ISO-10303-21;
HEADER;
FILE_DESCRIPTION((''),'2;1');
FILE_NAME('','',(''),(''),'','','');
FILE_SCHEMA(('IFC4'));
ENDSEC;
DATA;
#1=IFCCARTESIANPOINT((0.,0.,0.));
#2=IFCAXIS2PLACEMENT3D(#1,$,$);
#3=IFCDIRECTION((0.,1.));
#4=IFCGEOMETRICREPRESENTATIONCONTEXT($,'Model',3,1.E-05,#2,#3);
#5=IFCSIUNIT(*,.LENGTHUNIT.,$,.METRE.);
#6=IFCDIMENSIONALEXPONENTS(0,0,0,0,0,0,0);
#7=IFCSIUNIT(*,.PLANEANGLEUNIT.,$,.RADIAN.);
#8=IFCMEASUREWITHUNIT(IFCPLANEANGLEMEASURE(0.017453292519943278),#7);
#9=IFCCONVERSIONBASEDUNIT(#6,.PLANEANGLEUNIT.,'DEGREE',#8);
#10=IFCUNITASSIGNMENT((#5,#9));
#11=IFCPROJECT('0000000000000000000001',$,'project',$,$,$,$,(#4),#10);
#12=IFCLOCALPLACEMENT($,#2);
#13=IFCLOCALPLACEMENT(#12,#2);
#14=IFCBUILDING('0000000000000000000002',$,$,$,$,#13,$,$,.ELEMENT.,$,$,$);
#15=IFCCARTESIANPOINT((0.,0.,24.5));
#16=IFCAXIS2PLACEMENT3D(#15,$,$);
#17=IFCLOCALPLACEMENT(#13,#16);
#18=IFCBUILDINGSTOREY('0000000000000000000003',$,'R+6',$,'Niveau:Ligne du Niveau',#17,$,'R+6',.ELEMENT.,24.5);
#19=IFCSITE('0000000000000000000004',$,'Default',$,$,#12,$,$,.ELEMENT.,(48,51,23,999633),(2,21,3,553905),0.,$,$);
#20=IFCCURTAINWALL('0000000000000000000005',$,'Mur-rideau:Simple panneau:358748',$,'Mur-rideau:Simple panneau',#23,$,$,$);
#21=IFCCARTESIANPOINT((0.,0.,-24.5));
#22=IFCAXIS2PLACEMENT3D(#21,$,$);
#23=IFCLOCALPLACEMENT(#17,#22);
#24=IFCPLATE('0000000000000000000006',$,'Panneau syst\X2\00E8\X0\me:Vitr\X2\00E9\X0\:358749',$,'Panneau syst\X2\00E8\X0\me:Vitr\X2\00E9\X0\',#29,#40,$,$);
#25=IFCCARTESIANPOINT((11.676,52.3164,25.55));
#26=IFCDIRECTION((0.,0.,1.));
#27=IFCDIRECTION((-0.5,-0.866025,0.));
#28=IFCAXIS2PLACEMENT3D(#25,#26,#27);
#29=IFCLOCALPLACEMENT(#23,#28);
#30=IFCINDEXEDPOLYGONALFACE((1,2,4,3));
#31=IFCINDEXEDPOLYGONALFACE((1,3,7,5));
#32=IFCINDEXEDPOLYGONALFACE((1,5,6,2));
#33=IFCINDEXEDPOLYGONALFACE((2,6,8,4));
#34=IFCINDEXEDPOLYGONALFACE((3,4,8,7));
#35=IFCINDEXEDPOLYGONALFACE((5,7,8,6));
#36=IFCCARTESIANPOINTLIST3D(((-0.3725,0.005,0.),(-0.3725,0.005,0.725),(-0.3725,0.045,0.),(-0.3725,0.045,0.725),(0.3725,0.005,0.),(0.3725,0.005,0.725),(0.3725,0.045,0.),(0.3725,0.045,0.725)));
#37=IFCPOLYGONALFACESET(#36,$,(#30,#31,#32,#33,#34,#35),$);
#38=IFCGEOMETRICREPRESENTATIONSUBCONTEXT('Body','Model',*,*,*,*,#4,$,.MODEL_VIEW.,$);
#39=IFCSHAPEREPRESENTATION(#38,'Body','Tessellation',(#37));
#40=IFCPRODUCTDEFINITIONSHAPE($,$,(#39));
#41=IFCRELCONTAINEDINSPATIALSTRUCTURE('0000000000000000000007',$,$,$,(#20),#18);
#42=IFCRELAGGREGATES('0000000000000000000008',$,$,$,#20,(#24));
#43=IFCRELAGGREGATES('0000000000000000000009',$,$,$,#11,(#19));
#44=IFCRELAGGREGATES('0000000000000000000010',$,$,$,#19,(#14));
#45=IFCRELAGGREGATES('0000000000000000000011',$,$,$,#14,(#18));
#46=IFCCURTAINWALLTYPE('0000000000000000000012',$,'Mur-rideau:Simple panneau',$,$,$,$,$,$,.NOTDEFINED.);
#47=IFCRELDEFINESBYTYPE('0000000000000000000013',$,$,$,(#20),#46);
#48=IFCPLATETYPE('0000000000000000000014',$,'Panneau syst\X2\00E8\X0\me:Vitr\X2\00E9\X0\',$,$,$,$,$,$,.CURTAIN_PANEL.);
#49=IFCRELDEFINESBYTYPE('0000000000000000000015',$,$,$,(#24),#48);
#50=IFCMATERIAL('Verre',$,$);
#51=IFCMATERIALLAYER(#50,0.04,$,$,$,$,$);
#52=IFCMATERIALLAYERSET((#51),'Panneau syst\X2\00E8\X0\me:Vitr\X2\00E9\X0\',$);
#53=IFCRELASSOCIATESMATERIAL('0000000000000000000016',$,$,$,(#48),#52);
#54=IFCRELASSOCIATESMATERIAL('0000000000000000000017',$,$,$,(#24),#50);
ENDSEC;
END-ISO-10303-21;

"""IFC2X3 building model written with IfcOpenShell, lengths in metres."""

from ifc_helpers import new_model, entity, si_unit, converted_unit, direction, frame, frame_2d, origin, place, context, subcontext, project, spatial, rectangle, extrude, source, transform, mapped, material, layer, layer_set, type_object, type_shapes, element, aggregate, save


model = new_model("IFC2X3")

# Units and contexts
model_context = context("Model", 3, precision=1e-05, world=origin(), true_north=direction((0.0, 1.0)))
body_context = subcontext(model_context, "Body", "Model", "MODEL_VIEW")
ifc_project = project(units=[si_unit("LENGTHUNIT", "METRE"), converted_unit("PLANEANGLEUNIT", "DEGREE", entity("IfcPlaneAngleMeasure", 0.017453292519943278), si_unit("PLANEANGLEUNIT", "RADIAN"), dimensions=[0, 0, 0, 0, 0, 0, 0])], contexts=[model_context])

# Site, building, storey
site_placement = place(None, origin())
site = spatial("IfcSite", under=ifc_project, at=site_placement, Name="Default", CompositionType="ELEMENT", RefLatitude=(48, 51, 23, 999633), RefLongitude=(2, 21, 3, 553905), RefElevation=0.0)
building_placement = place(site_placement, origin())
building = spatial("IfcBuilding", under=site, at=building_placement, CompositionType="ELEMENT")
storey_placement = place(building_placement, frame((0.0, 0.0, 24.5)))
storey = spatial("IfcBuildingStorey", under=building, at=storey_placement, Name="R+6", ObjectType="Niveau:Ligne du Niveau", LongName="R+6", CompositionType="ELEMENT", Elevation=24.5)

# Shared definitions
curtain_wall_type = type_object("IfcCurtainWallType", Name="Mur-rideau:Simple panneau", PredefinedType="NOTDEFINED")

# Curtain wall
curtain_wall_1_placement = place(storey_placement, frame((0.0, 0.0, -24.5)))
curtain_wall_1 = element("IfcCurtainWall", 1, at=curtain_wall_1_placement, inside=storey, type_object=curtain_wall_type, Name="Mur-rideau:Simple panneau:358748", ObjectType="Mur-rideau:Simple panneau")

# Plate
ifc_material_1 = material(Name="Verre")
ifc_layer_1 = layer(ifc_material_1, 0.04)
ifc_layer_set_1 = layer_set([ifc_layer_1], Name="Panneau système:Vitré")
plate_type_1 = type_object("IfcPlateType", Name="Panneau système:Vitré", PredefinedType="CURTAIN_PANEL", material=ifc_layer_set_1)
shared_shape_1 = source(origin(), body_context, "Body", "SweptSolid", [
    extrude(rectangle(XDim=0.04, YDim=0.745, at=frame_2d((0.0, 0.0), x_axis=(1.0, 0.0))), frame((0.0, 0.025, 0.0), z_axis=(0.0, 0.0, 1.0), x_axis=(0.0, 1.0, 0.0)), (0.0, 0.0, 1.0), 0.725),
])
type_shapes(plate_type_1, [shared_shape_1])
plate_1_placement = place(curtain_wall_1_placement, frame((11.676, 52.3164, 25.55), z_axis=(0.0, 0.0, 1.0), x_axis=(-0.5, -0.866025, 0.0)))
plate_1 = element("IfcPlate", 2, at=plate_1_placement, type_object=plate_type_1, material=ifc_material_1, Name="Panneau système:Vitré:358749", ObjectType="Panneau système:Vitré", context=body_context, shape_type="MappedRepresentation", body=[
    mapped(shared_shape_1, transform((0.0, 0.0, 0.0), scale=1.0)),
])
aggregate(curtain_wall_1, [plate_1])

save(model, "model.ifc")
